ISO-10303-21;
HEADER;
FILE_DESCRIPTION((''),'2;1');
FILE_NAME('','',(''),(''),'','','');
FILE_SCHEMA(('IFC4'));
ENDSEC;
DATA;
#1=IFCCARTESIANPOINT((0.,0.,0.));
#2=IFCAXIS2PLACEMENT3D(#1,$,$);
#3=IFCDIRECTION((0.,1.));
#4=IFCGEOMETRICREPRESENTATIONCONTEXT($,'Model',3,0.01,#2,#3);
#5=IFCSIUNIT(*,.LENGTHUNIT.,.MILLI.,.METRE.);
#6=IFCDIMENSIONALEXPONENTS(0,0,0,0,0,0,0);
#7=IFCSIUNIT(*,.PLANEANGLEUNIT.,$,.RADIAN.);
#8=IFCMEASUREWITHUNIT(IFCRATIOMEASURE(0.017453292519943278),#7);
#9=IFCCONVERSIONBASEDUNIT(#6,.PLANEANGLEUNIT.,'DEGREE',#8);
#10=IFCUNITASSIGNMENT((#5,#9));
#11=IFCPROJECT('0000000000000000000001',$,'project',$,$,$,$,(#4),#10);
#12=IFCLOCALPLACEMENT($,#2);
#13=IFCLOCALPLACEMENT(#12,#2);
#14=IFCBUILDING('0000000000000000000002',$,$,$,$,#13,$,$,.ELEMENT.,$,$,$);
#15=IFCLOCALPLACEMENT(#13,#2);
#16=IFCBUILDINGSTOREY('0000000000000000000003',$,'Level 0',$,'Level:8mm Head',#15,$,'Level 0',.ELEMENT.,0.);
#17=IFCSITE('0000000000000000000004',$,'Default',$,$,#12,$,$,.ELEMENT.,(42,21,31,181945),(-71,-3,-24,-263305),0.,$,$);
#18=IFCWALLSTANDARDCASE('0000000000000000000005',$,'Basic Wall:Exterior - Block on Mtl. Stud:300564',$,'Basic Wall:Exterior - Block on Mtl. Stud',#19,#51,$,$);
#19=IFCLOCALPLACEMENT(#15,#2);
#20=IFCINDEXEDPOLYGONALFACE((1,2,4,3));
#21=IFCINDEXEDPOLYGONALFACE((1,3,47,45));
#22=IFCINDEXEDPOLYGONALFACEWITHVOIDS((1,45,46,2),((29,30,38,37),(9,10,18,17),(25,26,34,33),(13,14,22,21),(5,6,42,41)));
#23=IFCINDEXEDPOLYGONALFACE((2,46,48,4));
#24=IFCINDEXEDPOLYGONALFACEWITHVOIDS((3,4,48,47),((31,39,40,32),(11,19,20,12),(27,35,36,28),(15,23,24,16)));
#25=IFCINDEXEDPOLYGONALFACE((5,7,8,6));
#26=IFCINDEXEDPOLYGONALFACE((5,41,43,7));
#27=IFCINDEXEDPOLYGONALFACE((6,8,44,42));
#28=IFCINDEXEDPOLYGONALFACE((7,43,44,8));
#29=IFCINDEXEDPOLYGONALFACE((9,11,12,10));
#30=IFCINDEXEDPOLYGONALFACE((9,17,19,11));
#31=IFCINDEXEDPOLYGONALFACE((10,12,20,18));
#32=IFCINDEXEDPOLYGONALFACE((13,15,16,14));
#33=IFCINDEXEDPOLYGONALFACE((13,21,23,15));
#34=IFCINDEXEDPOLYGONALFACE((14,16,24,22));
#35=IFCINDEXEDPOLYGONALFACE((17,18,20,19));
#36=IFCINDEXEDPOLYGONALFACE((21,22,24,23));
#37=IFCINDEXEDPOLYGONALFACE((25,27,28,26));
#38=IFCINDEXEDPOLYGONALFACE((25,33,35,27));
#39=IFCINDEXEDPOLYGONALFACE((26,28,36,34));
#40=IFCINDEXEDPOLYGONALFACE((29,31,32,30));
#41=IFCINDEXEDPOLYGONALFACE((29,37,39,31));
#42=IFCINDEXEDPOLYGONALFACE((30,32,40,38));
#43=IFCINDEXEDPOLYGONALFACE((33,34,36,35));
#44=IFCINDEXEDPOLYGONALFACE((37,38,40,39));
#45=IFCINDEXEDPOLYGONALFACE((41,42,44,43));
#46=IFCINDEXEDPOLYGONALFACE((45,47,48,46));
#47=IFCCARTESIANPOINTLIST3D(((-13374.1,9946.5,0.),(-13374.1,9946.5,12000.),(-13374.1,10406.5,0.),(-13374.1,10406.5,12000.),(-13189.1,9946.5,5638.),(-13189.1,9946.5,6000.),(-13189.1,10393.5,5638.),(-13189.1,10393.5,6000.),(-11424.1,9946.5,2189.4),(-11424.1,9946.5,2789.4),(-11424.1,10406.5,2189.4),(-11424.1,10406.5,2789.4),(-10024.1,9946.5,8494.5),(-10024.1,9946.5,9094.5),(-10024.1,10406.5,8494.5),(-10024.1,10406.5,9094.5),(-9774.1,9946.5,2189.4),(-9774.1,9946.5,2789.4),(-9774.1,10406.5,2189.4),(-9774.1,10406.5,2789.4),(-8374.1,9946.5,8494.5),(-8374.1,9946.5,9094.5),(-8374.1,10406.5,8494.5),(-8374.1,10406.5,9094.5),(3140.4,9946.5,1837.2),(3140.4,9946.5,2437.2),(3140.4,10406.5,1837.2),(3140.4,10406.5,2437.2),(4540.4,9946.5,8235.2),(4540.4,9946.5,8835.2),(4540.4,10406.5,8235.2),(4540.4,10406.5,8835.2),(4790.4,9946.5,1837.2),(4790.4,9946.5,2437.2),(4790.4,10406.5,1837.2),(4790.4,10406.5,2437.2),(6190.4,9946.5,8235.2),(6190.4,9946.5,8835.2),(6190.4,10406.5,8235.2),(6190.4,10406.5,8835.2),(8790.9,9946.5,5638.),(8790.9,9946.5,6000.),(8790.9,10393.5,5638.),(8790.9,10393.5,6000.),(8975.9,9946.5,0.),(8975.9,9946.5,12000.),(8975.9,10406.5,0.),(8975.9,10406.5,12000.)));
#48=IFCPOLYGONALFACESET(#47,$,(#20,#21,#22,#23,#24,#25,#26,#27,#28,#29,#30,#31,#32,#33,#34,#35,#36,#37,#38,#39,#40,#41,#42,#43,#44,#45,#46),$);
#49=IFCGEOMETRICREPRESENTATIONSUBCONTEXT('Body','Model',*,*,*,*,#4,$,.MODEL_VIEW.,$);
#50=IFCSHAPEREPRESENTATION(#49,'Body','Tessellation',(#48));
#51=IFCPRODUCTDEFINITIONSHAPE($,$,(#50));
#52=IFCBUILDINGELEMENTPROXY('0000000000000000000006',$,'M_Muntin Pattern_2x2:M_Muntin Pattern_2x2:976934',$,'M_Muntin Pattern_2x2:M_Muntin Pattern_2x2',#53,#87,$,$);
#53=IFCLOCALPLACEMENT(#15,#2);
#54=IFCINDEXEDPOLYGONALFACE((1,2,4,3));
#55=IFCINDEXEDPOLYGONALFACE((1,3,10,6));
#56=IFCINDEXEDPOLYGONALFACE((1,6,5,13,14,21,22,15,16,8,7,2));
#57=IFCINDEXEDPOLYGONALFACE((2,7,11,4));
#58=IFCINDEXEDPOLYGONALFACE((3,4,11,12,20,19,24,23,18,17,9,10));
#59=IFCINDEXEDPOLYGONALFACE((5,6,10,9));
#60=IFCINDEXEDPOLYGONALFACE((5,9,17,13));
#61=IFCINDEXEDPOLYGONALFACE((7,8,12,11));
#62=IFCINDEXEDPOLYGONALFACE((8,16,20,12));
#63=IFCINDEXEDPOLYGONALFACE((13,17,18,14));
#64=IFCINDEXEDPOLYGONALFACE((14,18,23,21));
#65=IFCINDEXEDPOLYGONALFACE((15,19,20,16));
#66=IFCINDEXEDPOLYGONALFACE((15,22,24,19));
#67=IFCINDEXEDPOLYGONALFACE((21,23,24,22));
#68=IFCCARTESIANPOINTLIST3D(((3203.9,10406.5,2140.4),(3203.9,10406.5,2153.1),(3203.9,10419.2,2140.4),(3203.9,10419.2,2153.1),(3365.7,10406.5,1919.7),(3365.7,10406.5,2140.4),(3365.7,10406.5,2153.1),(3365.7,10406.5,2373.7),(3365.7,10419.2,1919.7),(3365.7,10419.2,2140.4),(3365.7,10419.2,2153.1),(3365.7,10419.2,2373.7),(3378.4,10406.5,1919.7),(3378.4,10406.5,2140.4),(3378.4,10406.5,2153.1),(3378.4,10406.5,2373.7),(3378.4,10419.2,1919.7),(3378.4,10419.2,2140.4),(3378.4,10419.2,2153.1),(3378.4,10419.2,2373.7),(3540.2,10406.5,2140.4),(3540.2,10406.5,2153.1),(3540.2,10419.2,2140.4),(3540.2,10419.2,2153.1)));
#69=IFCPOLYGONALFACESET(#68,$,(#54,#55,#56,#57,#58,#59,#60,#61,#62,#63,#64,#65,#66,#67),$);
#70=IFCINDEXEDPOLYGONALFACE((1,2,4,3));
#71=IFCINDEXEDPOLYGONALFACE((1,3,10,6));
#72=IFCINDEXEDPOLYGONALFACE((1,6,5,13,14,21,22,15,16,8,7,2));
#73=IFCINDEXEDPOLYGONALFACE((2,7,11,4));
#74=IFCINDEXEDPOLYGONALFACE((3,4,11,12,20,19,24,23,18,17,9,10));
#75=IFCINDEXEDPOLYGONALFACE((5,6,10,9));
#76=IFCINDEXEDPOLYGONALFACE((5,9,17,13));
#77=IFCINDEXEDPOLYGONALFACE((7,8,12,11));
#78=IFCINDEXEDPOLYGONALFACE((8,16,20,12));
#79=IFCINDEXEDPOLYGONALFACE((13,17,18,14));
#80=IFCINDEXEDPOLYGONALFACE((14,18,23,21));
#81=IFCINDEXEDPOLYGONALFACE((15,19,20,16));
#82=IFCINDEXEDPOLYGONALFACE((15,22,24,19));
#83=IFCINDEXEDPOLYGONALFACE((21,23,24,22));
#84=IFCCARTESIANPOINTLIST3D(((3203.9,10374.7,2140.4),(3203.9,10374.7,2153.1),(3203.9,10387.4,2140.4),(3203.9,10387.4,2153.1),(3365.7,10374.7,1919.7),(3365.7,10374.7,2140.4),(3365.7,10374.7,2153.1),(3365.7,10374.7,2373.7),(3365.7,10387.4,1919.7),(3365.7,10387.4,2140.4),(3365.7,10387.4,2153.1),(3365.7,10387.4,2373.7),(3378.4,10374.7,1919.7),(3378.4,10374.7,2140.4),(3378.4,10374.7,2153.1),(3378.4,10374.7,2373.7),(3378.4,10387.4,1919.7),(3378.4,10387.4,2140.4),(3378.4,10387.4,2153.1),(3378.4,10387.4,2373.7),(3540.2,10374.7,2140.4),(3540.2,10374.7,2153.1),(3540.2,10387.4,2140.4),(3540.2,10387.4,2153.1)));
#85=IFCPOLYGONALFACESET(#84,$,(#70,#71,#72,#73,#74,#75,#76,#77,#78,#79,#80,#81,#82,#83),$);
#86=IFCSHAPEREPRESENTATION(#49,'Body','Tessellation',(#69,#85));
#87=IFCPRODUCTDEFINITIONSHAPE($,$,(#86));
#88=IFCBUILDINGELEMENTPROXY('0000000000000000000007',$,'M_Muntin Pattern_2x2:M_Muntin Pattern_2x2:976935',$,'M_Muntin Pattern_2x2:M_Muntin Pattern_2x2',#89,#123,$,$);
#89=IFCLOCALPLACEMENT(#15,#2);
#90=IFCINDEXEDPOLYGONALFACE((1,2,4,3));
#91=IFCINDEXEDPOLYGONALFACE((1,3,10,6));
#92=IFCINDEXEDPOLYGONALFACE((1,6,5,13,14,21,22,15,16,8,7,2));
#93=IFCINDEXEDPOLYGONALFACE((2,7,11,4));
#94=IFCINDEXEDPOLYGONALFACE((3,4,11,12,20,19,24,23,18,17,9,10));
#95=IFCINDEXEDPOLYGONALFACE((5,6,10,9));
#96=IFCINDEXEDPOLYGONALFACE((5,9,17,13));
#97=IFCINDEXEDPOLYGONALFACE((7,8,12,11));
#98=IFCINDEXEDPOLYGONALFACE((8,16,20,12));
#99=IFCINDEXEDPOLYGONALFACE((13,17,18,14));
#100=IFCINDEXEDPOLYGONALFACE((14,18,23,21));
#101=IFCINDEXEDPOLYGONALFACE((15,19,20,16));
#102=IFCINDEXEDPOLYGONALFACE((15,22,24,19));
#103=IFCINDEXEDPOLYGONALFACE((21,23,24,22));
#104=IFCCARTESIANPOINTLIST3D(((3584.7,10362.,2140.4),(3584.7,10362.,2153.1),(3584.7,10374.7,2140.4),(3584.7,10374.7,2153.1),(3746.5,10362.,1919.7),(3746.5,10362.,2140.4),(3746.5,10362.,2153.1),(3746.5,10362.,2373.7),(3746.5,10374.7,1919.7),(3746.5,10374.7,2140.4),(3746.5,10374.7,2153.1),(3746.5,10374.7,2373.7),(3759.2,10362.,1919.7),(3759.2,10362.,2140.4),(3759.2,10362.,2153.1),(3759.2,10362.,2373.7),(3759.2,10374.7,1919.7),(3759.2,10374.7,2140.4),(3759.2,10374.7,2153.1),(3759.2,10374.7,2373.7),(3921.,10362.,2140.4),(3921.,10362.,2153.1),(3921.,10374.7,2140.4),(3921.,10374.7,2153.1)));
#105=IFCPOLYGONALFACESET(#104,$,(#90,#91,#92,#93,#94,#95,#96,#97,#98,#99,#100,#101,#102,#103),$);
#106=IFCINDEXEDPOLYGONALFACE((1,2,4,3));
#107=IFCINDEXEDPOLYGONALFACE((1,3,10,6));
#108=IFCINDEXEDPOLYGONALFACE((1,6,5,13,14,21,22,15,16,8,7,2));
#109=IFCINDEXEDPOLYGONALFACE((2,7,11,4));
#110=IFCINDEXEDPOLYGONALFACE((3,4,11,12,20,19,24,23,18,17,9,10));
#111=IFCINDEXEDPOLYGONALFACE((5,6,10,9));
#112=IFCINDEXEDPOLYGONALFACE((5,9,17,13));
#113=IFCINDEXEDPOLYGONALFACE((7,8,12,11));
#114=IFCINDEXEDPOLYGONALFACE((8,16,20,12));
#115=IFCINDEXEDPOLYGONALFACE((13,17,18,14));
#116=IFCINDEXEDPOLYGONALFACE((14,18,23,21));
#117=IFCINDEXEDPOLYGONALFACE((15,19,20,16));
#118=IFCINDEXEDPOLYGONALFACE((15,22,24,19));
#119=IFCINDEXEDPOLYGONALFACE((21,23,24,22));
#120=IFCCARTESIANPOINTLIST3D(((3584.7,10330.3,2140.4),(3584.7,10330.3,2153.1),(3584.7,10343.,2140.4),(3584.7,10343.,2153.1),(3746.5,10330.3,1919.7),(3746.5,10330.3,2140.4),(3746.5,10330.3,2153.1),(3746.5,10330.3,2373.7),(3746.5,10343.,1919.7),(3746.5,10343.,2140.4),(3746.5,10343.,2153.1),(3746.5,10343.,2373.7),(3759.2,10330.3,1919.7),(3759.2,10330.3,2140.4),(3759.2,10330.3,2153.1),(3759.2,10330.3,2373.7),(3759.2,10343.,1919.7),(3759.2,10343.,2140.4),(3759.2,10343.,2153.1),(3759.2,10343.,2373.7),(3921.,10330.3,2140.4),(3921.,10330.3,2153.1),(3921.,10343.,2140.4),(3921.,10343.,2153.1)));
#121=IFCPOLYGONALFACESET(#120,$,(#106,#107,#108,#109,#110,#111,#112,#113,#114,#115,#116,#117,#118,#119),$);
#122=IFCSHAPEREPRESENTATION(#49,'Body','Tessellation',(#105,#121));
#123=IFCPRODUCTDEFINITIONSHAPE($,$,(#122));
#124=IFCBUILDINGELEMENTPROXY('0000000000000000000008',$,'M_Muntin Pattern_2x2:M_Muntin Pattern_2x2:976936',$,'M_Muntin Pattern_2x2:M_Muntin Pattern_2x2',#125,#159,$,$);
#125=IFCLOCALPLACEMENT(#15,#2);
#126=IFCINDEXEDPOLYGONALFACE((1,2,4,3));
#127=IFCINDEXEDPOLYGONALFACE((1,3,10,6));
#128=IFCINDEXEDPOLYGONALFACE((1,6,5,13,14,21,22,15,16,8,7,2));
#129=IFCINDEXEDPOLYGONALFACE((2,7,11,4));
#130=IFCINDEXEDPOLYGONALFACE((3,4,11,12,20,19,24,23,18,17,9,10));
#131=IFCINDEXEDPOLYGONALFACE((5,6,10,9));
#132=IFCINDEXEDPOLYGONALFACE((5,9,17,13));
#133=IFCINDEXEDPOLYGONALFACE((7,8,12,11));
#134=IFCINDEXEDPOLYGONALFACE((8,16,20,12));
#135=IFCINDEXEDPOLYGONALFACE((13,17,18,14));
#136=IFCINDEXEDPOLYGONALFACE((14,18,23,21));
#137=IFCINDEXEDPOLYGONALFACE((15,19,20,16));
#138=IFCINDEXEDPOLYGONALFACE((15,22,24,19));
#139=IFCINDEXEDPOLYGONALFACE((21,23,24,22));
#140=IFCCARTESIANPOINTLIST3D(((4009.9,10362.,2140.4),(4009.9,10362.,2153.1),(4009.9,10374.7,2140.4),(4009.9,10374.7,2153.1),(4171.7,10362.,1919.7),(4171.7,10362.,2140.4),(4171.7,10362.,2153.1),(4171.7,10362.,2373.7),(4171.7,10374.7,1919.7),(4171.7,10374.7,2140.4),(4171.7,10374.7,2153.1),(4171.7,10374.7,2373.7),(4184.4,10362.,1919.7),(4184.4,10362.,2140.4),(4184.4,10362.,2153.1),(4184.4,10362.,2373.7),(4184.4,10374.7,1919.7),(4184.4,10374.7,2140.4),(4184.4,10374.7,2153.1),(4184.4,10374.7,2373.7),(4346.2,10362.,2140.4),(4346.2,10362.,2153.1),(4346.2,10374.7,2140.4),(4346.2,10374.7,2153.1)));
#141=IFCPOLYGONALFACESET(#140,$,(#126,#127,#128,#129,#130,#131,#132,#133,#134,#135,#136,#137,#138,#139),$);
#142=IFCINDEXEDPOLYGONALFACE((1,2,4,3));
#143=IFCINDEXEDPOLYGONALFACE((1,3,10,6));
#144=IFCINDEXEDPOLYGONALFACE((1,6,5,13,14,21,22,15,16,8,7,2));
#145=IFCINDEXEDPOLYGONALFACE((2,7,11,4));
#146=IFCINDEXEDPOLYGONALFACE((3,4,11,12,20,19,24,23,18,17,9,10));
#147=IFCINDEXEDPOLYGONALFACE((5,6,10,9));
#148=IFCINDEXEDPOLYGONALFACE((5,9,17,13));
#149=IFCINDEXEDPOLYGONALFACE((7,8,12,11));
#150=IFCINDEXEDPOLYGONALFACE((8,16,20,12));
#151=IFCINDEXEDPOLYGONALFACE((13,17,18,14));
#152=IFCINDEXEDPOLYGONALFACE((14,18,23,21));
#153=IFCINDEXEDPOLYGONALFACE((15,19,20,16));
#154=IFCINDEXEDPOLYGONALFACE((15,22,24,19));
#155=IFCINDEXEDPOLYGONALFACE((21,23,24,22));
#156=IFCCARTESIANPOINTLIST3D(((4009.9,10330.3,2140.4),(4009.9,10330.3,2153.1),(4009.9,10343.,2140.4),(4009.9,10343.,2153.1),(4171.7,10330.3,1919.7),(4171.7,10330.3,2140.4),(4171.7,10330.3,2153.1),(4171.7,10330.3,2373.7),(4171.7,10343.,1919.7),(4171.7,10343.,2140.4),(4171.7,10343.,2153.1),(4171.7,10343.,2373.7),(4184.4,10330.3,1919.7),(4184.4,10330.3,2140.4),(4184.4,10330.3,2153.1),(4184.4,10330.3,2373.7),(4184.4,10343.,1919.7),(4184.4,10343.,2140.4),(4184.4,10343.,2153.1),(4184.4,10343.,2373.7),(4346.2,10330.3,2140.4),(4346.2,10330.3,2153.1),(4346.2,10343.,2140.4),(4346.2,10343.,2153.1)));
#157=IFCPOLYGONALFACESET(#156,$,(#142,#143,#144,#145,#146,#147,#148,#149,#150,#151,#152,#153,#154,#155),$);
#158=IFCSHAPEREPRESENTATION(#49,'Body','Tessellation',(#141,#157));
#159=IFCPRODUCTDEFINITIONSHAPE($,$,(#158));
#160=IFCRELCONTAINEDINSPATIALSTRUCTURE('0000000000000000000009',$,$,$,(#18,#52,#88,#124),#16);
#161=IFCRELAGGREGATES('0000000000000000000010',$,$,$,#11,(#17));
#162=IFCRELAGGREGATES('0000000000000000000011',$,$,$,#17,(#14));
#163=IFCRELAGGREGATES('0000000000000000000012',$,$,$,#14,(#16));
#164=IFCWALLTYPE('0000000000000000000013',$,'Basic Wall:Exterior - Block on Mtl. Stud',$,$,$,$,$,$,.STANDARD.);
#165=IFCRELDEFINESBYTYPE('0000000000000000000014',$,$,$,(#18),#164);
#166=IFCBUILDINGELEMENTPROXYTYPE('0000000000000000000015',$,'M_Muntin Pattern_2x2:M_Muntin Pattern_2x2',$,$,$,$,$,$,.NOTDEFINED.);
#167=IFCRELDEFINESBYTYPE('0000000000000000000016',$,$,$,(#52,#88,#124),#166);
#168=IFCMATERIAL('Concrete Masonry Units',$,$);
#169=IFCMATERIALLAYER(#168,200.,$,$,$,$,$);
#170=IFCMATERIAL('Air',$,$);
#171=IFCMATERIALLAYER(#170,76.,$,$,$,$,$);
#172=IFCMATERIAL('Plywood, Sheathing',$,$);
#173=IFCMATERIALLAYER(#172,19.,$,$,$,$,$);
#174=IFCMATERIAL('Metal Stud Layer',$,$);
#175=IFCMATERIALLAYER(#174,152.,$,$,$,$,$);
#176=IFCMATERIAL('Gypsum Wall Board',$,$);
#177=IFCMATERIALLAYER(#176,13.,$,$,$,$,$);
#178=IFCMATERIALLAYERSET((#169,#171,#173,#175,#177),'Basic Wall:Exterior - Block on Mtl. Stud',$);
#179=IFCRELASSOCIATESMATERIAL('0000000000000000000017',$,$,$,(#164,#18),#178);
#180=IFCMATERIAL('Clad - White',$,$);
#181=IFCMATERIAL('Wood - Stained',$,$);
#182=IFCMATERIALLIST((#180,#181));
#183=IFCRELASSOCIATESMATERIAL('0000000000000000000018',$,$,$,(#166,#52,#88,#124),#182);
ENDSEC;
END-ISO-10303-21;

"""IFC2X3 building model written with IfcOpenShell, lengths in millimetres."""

from ifc_helpers import new_model, entity, si_unit, converted_unit, direction, frame, frame_2d, origin, place, context, subcontext, project, spatial, polyline, rectangle, outline, extrude, source, transform, mapped, material, material_list, layer, layer_set, layer_usage, type_object, type_shapes, element, save


model = new_model("IFC2X3")

# Units and contexts
model_context = context("Model", 3, precision=0.01, world=origin(), true_north=direction((0.0, 1.0)))
body_context = subcontext(model_context, "Body", "Model", "MODEL_VIEW")
ifc_project = project(units=[si_unit("LENGTHUNIT", "METRE", prefix="MILLI"), converted_unit("PLANEANGLEUNIT", "DEGREE", entity("IfcRatioMeasure", 0.017453292519943278), si_unit("PLANEANGLEUNIT", "RADIAN"), dimensions=[0, 0, 0, 0, 0, 0, 0])], contexts=[model_context])

# Site, building, storey
site_placement = place(None, origin())
site = spatial("IfcSite", under=ifc_project, at=site_placement, Name="Default", CompositionType="ELEMENT", RefLatitude=(42, 21, 31, 181945), RefLongitude=(-71, -3, -24, -263305), RefElevation=0.0)
building_placement = place(site_placement, origin())
building = spatial("IfcBuilding", under=site, at=building_placement, CompositionType="ELEMENT")
storey_placement = place(building_placement, origin())
storey = spatial("IfcBuildingStorey", under=building, at=storey_placement, Name="Level 0", ObjectType="Level:8mm Head", LongName="Level 0", CompositionType="ELEMENT", Elevation=0.0)

# Wall, openings
ifc_material_1 = material(Name="Concrete Masonry Units")
ifc_layer_1 = layer(ifc_material_1, 200.0)
ifc_material_2 = material(Name="Air")
ifc_layer_2 = layer(ifc_material_2, 76.0)
ifc_material_3 = material(Name="Plywood, Sheathing")
ifc_layer_3 = layer(ifc_material_3, 19.0)
ifc_material_4 = material(Name="Metal Stud Layer")
ifc_layer_4 = layer(ifc_material_4, 152.0)
ifc_material_5 = material(Name="Gypsum Wall Board")
ifc_layer_5 = layer(ifc_material_5, 13.0)
ifc_layer_set = layer_set([ifc_layer_1, ifc_layer_2, ifc_layer_3, ifc_layer_4, ifc_layer_5], Name="Basic Wall:Exterior - Block on Mtl. Stud")
ifc_layer_usage = layer_usage(ifc_layer_set, "AXIS2", "POSITIVE", -230.0)
wall_type = type_object("IfcWallType", Name="Basic Wall:Exterior - Block on Mtl. Stud", PredefinedType="STANDARD", material=ifc_layer_set)
wall_placement = place(storey_placement, frame((-13374.1, 10176.5, 0.0)))
wall = element("IfcWallStandardCase", 1, at=wall_placement, inside=storey, type_object=wall_type, material=ifc_layer_usage, Name="Basic Wall:Exterior - Block on Mtl. Stud:300564", ObjectType="Basic Wall:Exterior - Block on Mtl. Stud", context=body_context, shape_type="SweptSolid", body=[
    extrude(rectangle(XDim=22350.0, YDim=460.0, at=frame_2d((11175.0, 0.0), x_axis=(-1.0, 0.0))), origin(), (0.0, 0.0, 1.0), 12000.0),
])
opening_1_placement = place(storey_placement, frame((-13374.1, 10176.5, 0.0)))
element("IfcOpeningElement", 2, at=opening_1_placement, cuts=wall, ObjectType="Opening", context=body_context, shape_type="SweptSolid", body=[
    extrude(rectangle(XDim=21980.0, YDim=447.0, at=frame_2d((0.0, -74.5), x_axis=(1.0, 0.0))), frame((11175.0, -81.0, 5638.0), z_axis=(0.0, 0.0, 1.0), x_axis=(-1.0, 0.0, 0.0)), (0.0, 0.0, 1.0), 362.0),
])
opening_2_placement = place(wall_placement, frame((16514.5, -230.0, 1837.2)))
element("IfcOpeningElement", 3, at=opening_2_placement, cuts=wall, ObjectType="Opening", context=body_context, shape_type="SweptSolid", body=[
    extrude(rectangle(XDim=600.0, YDim=1650.0, at=frame_2d((300.0, 825.0), x_axis=(-1.0, 0.0))), frame((0.0, 0.0, 0.0), z_axis=(0.0, 1.0, 0.0), x_axis=(0.0, 0.0, 1.0)), (0.0, 0.0, 1.0), 460.0),
])
opening_3_placement = place(wall_placement, frame((1950.0, -230.0, 2189.4)))
element("IfcOpeningElement", 4, at=opening_3_placement, cuts=wall, ObjectType="Opening", context=body_context, shape_type="SweptSolid", body=[
    extrude(rectangle(XDim=600.0, YDim=1650.0, at=frame_2d((300.0, 825.0), x_axis=(-1.0, 0.0))), frame((0.0, 0.0, 0.0), z_axis=(0.0, 1.0, 0.0), x_axis=(0.0, 0.0, 1.0)), (0.0, 0.0, 1.0), 460.0),
])
opening_4_placement = place(wall_placement, frame((17914.5, -230.0, 8235.2)))
element("IfcOpeningElement", 5, at=opening_4_placement, cuts=wall, ObjectType="Opening", context=body_context, shape_type="SweptSolid", body=[
    extrude(rectangle(XDim=600.0, YDim=1650.0, at=frame_2d((300.0, 825.0), x_axis=(-1.0, 0.0))), frame((0.0, 0.0, 0.0), z_axis=(0.0, 1.0, 0.0), x_axis=(0.0, 0.0, 1.0)), (0.0, 0.0, 1.0), 460.0),
])
opening_5_placement = place(wall_placement, frame((3350.0, -230.0, 8494.5)))
element("IfcOpeningElement", 6, at=opening_5_placement, cuts=wall, ObjectType="Opening", context=body_context, shape_type="SweptSolid", body=[
    extrude(rectangle(XDim=600.0, YDim=1650.0, at=frame_2d((300.0, 825.0), x_axis=(-1.0, 0.0))), frame((0.0, 0.0, 0.0), z_axis=(0.0, 1.0, 0.0), x_axis=(0.0, 0.0, 1.0)), (0.0, 0.0, 1.0), 460.0),
])

# Building element proxies
ifc_material_6 = material(Name="Clad - White")
ifc_material_7 = material(Name="Wood - Stained")
ifc_material_list = material_list([ifc_material_6, ifc_material_7])
building_element_proxy_type_1 = type_object("IfcBuildingElementProxyType", Name="M_Muntin Pattern_2x2:M_Muntin Pattern_2x2", PredefinedType="NOTDEFINED", material=ifc_material_list)
shared_shape_1 = source(origin(), body_context, "Body", "SweptSolid", [
    extrude(outline(polyline([(6.4, -6.4), (227.0, -6.4), (227.0, 6.3), (6.4, 6.3), (6.4, 168.2), (-6.3, 168.2), (-6.3, 6.3), (-227.0, 6.3), (-227.0, -6.4), (-6.3, -6.4), (-6.3, -168.1), (6.4, -168.1), (6.4, -6.4)])), frame((0.0, 9.5, 227.0), z_axis=(0.0, 1.0, 0.0), x_axis=(0.0, 0.0, 1.0)), (0.0, 0.0, 1.0), 12.7),
    extrude(outline(polyline([(6.4, -6.4), (227.0, -6.4), (227.0, 6.3), (6.4, 6.3), (6.4, 168.2), (-6.3, 168.2), (-6.3, 6.3), (-227.0, 6.3), (-227.0, -6.4), (-6.3, -6.4), (-6.3, -168.1), (6.4, -168.1), (6.4, -6.4)])), frame((0.0, -22.2, 227.0), z_axis=(0.0, 1.0, 0.0), x_axis=(0.0, 0.0, 1.0)), (0.0, 0.0, 1.0), 12.7),
])
type_shapes(building_element_proxy_type_1, [shared_shape_1])
for number, where, name in (
    (7, (3372.1, 10396.9, 1919.7), "M_Muntin Pattern_2x2:M_Muntin Pattern_2x2:976934"),
    (8, (3752.8, 10352.5, 1919.7), "M_Muntin Pattern_2x2:M_Muntin Pattern_2x2:976935"),
    (9, (4178.0, 10352.5, 1919.7), "M_Muntin Pattern_2x2:M_Muntin Pattern_2x2:976936"),
):
    element("IfcBuildingElementProxy", number, at=place(storey_placement, frame(where)), inside=storey, type_object=building_element_proxy_type_1, material=ifc_material_list, Name=name, ObjectType="M_Muntin Pattern_2x2:M_Muntin Pattern_2x2", context=body_context, shape_type="MappedRepresentation", body=[
        mapped(shared_shape_1, transform((0.0, 0.0, 0.0), scale=1.0)),
    ])

save(model, "model.ifc")
